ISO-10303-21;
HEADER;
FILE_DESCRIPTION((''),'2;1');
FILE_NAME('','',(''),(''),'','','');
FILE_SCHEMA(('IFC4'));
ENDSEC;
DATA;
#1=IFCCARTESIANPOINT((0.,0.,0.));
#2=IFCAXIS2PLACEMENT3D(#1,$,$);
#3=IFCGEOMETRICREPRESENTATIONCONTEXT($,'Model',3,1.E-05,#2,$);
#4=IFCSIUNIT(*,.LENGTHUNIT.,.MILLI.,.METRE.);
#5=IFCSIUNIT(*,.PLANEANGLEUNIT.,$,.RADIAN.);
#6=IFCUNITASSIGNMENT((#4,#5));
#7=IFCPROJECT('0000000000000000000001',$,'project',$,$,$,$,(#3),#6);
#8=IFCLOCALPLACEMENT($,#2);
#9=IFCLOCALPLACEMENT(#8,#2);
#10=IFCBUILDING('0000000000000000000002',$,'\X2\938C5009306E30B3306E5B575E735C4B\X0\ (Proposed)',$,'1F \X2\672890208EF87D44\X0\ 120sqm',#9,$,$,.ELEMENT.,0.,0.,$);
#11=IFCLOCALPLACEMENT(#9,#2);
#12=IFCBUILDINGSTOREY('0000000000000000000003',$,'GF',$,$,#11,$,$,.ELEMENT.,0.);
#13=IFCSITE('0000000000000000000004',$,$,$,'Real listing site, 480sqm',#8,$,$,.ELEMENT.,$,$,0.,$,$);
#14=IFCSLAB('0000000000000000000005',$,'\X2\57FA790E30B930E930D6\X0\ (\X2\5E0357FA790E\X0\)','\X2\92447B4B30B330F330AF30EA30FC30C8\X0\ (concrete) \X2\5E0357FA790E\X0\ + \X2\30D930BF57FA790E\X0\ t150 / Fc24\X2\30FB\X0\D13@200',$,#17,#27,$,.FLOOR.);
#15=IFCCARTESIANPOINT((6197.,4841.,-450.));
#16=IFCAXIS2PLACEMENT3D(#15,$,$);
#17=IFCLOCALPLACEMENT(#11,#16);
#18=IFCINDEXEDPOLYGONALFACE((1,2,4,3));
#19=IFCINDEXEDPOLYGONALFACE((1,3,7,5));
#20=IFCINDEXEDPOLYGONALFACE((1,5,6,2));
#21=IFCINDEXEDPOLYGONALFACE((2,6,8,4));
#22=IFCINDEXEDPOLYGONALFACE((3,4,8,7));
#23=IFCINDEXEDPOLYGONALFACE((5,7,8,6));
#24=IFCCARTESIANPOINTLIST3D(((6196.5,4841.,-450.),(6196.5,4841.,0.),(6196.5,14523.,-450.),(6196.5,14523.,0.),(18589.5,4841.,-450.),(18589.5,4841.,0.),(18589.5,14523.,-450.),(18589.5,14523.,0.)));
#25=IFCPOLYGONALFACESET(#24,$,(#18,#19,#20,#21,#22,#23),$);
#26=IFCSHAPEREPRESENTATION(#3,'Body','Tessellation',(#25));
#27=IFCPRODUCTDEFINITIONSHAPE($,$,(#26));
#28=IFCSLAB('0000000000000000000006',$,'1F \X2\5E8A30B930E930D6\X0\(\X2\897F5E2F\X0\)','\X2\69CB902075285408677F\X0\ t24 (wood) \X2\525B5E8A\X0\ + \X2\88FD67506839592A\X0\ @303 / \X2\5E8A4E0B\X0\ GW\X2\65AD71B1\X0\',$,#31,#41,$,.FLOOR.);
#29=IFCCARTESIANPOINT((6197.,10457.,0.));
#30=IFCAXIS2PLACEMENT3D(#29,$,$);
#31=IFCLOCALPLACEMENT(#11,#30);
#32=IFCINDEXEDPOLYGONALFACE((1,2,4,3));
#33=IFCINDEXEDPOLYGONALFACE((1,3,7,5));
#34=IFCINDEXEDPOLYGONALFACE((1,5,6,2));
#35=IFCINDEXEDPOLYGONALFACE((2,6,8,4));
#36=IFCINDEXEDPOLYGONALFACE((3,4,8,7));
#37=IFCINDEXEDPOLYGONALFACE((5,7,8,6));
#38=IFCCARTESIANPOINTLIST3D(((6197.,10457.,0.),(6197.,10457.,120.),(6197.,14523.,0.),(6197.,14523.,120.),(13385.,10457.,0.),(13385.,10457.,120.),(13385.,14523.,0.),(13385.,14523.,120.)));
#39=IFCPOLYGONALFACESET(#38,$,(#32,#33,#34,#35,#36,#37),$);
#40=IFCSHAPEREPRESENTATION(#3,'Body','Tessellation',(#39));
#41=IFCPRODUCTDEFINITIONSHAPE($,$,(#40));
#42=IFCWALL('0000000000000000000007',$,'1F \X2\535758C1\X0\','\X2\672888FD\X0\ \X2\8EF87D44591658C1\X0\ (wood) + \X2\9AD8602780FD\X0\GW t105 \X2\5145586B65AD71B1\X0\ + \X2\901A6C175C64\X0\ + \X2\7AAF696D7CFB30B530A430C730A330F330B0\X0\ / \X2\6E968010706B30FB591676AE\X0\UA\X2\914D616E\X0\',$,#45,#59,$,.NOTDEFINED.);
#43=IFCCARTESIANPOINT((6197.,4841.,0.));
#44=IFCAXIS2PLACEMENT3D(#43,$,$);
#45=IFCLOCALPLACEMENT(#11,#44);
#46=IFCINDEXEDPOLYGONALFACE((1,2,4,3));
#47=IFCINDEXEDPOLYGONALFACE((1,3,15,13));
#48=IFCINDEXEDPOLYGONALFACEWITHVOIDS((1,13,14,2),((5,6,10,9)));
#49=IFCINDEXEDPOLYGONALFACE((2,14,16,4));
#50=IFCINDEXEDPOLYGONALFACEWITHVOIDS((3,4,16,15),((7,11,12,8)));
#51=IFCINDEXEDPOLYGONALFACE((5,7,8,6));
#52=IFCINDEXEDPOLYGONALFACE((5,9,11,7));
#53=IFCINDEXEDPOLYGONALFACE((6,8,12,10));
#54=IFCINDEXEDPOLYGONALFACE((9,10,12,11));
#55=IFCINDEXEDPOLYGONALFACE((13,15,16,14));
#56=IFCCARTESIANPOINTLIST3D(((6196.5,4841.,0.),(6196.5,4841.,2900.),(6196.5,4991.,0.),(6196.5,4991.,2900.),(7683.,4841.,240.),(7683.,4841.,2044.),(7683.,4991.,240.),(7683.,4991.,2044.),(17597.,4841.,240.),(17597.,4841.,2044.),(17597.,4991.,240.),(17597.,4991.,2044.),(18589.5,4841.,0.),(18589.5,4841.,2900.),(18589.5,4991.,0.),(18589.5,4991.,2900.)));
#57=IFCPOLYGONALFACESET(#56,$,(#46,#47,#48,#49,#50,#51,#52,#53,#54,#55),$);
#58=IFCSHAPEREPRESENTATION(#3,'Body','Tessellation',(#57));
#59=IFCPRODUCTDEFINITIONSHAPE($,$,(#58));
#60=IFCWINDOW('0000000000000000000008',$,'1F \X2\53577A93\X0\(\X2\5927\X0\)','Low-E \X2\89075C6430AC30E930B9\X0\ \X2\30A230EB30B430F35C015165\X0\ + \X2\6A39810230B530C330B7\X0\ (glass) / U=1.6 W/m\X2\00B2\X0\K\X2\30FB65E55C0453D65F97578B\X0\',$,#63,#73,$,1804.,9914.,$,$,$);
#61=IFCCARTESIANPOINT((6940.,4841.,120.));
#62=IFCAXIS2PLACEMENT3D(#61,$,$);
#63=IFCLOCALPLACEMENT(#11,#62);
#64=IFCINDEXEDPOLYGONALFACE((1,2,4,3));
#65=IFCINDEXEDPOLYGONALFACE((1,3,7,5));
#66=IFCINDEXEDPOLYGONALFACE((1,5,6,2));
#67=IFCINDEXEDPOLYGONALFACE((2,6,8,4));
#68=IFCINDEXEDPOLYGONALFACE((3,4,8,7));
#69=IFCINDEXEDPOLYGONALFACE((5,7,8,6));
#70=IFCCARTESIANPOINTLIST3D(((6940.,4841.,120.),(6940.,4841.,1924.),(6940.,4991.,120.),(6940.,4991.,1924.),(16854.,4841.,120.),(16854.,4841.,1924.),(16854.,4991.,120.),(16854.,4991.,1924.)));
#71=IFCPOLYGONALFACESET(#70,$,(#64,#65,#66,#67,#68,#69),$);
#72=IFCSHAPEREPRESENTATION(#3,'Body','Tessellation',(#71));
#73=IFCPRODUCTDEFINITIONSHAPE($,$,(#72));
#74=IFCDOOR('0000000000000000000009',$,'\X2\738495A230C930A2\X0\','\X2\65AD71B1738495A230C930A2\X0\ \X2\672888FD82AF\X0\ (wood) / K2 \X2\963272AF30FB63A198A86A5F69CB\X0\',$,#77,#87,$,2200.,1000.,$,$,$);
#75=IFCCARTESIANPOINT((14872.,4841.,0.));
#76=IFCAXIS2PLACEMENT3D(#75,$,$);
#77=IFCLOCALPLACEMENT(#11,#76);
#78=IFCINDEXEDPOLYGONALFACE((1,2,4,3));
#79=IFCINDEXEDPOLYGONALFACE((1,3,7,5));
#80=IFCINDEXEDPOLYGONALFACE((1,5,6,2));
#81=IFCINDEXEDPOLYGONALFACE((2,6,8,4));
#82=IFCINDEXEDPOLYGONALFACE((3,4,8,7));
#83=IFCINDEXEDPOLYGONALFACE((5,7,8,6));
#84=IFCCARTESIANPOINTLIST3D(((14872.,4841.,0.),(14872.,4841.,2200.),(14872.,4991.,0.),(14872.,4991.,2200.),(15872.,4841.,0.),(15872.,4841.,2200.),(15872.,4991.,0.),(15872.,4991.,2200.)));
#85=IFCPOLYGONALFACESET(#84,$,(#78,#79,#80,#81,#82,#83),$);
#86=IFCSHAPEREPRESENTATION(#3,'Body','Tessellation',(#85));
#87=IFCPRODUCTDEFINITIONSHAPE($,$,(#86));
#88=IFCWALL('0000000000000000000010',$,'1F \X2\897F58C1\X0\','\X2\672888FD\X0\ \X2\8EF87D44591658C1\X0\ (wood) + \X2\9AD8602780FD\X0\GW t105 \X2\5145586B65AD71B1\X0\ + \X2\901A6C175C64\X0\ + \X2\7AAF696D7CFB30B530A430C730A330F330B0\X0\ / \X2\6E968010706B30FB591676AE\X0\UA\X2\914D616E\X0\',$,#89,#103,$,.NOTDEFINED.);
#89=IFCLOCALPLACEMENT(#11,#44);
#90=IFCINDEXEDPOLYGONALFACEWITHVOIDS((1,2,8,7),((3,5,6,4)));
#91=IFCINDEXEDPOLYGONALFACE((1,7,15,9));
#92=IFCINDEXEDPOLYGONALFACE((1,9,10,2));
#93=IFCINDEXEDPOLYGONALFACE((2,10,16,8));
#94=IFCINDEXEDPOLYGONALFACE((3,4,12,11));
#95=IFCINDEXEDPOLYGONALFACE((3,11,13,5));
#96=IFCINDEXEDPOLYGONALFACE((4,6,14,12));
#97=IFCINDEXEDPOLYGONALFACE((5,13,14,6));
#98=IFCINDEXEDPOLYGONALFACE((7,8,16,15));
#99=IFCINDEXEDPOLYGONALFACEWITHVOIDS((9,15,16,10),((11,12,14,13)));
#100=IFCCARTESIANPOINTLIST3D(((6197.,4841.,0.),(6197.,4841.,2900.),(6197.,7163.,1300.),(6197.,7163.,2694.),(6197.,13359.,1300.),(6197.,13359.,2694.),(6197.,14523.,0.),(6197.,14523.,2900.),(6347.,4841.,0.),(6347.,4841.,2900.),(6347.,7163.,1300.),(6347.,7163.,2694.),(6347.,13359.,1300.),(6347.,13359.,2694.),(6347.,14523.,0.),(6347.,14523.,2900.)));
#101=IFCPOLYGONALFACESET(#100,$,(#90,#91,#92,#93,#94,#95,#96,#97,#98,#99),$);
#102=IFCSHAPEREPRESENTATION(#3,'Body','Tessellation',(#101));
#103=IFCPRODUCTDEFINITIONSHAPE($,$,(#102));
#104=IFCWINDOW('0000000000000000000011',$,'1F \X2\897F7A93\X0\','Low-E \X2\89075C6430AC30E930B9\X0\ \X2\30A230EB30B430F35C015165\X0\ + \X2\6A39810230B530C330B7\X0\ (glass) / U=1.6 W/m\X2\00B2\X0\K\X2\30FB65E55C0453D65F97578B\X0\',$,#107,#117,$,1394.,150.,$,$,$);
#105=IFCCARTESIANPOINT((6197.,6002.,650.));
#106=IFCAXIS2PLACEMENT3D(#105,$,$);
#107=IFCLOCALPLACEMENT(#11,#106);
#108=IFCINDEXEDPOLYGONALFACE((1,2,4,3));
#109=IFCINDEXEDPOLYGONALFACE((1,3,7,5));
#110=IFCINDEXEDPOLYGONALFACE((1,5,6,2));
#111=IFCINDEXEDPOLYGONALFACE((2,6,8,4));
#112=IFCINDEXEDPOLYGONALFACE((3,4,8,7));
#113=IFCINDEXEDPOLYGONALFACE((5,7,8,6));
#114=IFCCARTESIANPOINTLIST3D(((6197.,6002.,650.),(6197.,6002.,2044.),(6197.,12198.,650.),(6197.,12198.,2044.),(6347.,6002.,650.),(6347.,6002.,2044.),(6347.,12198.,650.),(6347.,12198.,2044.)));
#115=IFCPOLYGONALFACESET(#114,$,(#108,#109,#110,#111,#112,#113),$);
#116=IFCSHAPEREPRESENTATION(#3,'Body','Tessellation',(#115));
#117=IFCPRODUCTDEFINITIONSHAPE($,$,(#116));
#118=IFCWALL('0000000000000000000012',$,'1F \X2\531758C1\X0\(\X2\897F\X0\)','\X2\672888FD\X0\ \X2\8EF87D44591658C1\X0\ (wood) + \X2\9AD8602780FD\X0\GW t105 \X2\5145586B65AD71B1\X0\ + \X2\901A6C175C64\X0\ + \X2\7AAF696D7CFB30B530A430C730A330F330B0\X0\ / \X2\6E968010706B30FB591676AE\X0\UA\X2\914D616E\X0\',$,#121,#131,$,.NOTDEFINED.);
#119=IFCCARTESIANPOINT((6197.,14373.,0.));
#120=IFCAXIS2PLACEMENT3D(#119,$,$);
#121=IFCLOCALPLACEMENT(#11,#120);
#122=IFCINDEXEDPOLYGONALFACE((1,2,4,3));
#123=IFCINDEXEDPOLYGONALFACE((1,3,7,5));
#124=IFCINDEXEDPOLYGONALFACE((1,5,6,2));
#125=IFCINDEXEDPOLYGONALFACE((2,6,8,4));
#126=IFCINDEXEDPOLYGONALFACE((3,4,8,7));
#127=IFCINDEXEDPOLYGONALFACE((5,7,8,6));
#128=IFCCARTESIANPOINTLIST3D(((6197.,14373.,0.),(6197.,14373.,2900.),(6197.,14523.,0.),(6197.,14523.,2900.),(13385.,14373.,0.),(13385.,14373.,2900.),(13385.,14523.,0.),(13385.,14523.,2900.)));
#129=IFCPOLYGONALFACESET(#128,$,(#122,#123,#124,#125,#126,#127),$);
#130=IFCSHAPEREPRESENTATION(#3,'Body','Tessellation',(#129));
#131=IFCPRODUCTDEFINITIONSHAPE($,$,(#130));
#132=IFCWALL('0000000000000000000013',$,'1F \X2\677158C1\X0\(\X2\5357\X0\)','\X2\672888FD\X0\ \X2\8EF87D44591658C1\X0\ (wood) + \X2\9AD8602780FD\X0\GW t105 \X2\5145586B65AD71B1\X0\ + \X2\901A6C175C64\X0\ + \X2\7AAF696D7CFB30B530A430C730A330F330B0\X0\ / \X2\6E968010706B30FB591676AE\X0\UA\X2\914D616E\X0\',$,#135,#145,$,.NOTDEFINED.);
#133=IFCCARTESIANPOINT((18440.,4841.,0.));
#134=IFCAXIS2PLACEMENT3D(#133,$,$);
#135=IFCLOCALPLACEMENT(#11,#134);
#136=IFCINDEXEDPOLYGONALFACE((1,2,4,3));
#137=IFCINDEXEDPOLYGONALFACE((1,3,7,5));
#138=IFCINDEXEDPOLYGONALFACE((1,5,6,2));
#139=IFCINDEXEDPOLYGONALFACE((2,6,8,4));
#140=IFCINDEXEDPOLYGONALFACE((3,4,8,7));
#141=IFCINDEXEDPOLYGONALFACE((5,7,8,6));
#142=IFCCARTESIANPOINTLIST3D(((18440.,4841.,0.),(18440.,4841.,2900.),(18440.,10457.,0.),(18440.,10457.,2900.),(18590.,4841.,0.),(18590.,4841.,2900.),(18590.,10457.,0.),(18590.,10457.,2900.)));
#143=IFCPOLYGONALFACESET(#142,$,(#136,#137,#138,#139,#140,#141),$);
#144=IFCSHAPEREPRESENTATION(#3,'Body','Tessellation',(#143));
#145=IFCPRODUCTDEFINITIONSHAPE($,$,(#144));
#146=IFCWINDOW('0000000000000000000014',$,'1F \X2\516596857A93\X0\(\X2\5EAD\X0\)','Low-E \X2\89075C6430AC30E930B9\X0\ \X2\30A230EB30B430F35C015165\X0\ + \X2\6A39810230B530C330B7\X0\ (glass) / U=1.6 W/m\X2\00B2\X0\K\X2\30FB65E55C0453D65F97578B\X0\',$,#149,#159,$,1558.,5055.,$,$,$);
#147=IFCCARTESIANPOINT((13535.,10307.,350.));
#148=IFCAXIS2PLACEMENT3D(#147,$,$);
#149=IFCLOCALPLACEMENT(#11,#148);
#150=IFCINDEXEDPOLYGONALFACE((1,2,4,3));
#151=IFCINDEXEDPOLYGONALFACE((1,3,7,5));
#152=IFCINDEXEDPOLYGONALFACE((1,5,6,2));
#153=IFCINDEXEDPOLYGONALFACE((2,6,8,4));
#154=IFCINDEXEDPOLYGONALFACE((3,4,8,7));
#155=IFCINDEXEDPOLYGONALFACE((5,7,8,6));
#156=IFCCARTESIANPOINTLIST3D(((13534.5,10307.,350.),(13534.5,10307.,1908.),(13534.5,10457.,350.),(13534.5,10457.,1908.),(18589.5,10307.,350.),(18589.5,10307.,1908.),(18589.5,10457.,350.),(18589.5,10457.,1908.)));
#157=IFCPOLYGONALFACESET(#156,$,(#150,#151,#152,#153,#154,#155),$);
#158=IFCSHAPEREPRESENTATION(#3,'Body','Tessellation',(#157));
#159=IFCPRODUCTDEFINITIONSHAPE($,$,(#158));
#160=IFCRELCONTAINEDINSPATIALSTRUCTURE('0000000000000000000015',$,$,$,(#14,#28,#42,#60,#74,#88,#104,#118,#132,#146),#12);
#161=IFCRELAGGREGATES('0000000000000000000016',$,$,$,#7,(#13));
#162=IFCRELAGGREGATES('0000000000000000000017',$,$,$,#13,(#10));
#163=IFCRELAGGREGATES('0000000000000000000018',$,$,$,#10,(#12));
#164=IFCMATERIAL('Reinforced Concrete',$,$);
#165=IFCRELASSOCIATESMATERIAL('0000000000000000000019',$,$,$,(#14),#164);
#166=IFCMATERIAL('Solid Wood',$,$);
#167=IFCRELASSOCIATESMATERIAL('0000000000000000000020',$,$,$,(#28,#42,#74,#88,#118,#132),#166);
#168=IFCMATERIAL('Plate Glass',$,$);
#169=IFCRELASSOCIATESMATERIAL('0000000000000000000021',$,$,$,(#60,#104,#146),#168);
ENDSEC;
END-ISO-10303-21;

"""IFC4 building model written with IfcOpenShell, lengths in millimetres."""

from ifc_helpers import new_model, si_unit, frame, frame_2d, origin, place, context, project, spatial, rectangle, extrude, material, element, fill, save


model = new_model("IFC4")

# Units and contexts
model_context = context("Model", 3, precision=1e-05, world=origin())
ifc_project = project(units=[si_unit("LENGTHUNIT", "METRE", prefix="MILLI"), si_unit("PLANEANGLEUNIT", "RADIAN")], contexts=[model_context])

# Site, building, storey
site_placement = place(None, origin())
site = spatial("IfcSite", under=ifc_project, at=site_placement, ObjectType="Real listing site, 480sqm", CompositionType="ELEMENT", RefElevation=0.0)
building_placement = place(site_placement, origin())
building = spatial("IfcBuilding", under=site, at=building_placement, Name="鎌倉のコの字平屋 (Proposed)", ObjectType="1F 木造軸組 120sqm", CompositionType="ELEMENT", ElevationOfRefHeight=0.0, ElevationOfTerrain=0.0)
storey_placement = place(building_placement, origin())
storey = spatial("IfcBuildingStorey", under=building, at=storey_placement, Name="GF", CompositionType="ELEMENT", Elevation=0.0)

# Slabs
ifc_material_1 = material(Name="Reinforced Concrete")
slab_1_placement = place(storey_placement, frame((6197.0, 4841.0, -450.0)))
element("IfcSlab", 1, at=slab_1_placement, inside=storey, material=ifc_material_1, Name="基礎スラブ (布基礎)", Description="鉄筋コンクリート (concrete) 布基礎 + ベタ基礎 t150 / Fc24・D13@200", PredefinedType="FLOOR", context=model_context, shape_type="SweptSolid", body=[
    extrude(rectangle(XDim=12393.0, YDim=9682.0, at=frame_2d((6196.0, 4841.0))), frame((6197.0, 4841.0, -450.0)), (0.0, 0.0, 1.0), 450.0),
])
ifc_material_2 = material(Name="Solid Wood")
slab_2_placement = place(storey_placement, frame((6197.0, 10457.0, 0.0)))
element("IfcSlab", 2, at=slab_2_placement, inside=storey, material=ifc_material_2, Name="1F 床スラブ(西帯)", Description="構造用合板 t24 (wood) 剛床 + 製材根太 @303 / 床下 GW断熱", PredefinedType="FLOOR", context=model_context, shape_type="SweptSolid", body=[
    extrude(rectangle(XDim=7188.0, YDim=4066.0, at=frame_2d((3594.0, 2033.0))), frame((6197.0, 10457.0, 0.0)), (0.0, 0.0, 1.0), 120.0),
])

# Wall, openings, window, door
wall_1_placement = place(storey_placement, frame((6197.0, 4841.0, 0.0)))
wall_1 = element("IfcWall", 3, at=wall_1_placement, inside=storey, material=ifc_material_2, Name="1F 南壁", Description="木製 軸組外壁 (wood) + 高性能GW t105 充填断熱 + 通気層 + 窯業系サイディング / 準耐火・外皮UA配慮", PredefinedType="NOTDEFINED", context=model_context, shape_type="SweptSolid", body=[
    extrude(rectangle(XDim=12393.0, YDim=150.0, at=frame_2d((6196.0, 75.0))), frame((6197.0, 4841.0, 0.0)), (0.0, 0.0, 1.0), 2900.0),
])
opening_1_placement = place(storey_placement, frame((6940.0, 4841.0, 120.0)))
opening_1 = element("IfcOpeningElement", 4, at=opening_1_placement, cuts=wall_1, PredefinedType="NOTDEFINED", context=model_context, shape_type="SweptSolid", body=[
    extrude(rectangle(XDim=9914.0, YDim=150.0, at=frame_2d((4957.0, 75.0))), frame((6940.0, 4841.0, 120.0)), (0.0, 0.0, 1.0), 1804.0),
])
opening_2_placement = place(storey_placement, frame((14872.0, 4841.0, 0.0)))
opening_2 = element("IfcOpeningElement", 5, at=opening_2_placement, cuts=wall_1, PredefinedType="NOTDEFINED", context=model_context, shape_type="SweptSolid", body=[
    extrude(rectangle(XDim=1000.0, YDim=150.0, at=frame_2d((500.0, 75.0))), frame((14872.0, 4841.0, 0.0)), (0.0, 0.0, 1.0), 2200.0),
])
ifc_material_3 = material(Name="Plate Glass")
window_1_placement = place(storey_placement, frame((6940.0, 4841.0, 120.0)))
window_1 = element("IfcWindow", 6, at=window_1_placement, inside=storey, material=ifc_material_3, Name="1F 南窓(大)", Description="Low-E 複層ガラス アルゴン封入 + 樹脂サッシ (glass) / U=1.6 W/m²K・日射取得型", OverallHeight=1804.0, OverallWidth=9914.0, context=model_context, shape_type="SweptSolid", body=[
    extrude(rectangle(XDim=9914.0, YDim=150.0, at=frame_2d((4957.0, 75.0))), frame((6940.0, 4841.0, 120.0)), (0.0, 0.0, 1.0), 1804.0),
])
fill(opening_1, window_1)
door_placement = place(storey_placement, frame((14872.0, 4841.0, 0.0)))
door = element("IfcDoor", 7, at=door_placement, inside=storey, material=ifc_material_2, Name="玄関ドア", Description="断熱玄関ドア 木製芯 (wood) / K2 防犯・採風機構", OverallHeight=2200.0, OverallWidth=1000.0, context=model_context, shape_type="SweptSolid", body=[
    extrude(rectangle(XDim=1000.0, YDim=150.0, at=frame_2d((500.0, 75.0))), frame((14872.0, 4841.0, 0.0)), (0.0, 0.0, 1.0), 2200.0),
])
fill(opening_2, door)

# Wall, opening, window
wall_2_placement = place(storey_placement, frame((6197.0, 4841.0, 0.0)))
wall_2 = element("IfcWall", 8, at=wall_2_placement, inside=storey, material=ifc_material_2, Name="1F 西壁", Description="木製 軸組外壁 (wood) + 高性能GW t105 充填断熱 + 通気層 + 窯業系サイディング / 準耐火・外皮UA配慮", PredefinedType="NOTDEFINED", context=model_context, shape_type="SweptSolid", body=[
    extrude(rectangle(XDim=150.0, YDim=9682.0, at=frame_2d((75.0, 4841.0))), frame((6197.0, 4841.0, 0.0)), (0.0, 0.0, 1.0), 2900.0),
])
opening_3_placement = place(storey_placement, frame((6197.0, 6002.0, 650.0)))
opening_3 = element("IfcOpeningElement", 9, at=opening_3_placement, cuts=wall_2, PredefinedType="NOTDEFINED", context=model_context, shape_type="SweptSolid", body=[
    extrude(rectangle(XDim=150.0, YDim=6196.0, at=frame_2d((75.0, 3098.0))), frame((6197.0, 6002.0, 650.0)), (0.0, 0.0, 1.0), 1394.0),
])
window_2_placement = place(storey_placement, frame((6197.0, 6002.0, 650.0)))
window_2 = element("IfcWindow", 10, at=window_2_placement, inside=storey, material=ifc_material_3, Name="1F 西窓", Description="Low-E 複層ガラス アルゴン封入 + 樹脂サッシ (glass) / U=1.6 W/m²K・日射取得型", OverallHeight=1394.0, OverallWidth=150.0, context=model_context, shape_type="SweptSolid", body=[
    extrude(rectangle(XDim=150.0, YDim=6196.0, at=frame_2d((75.0, 3098.0))), frame((6197.0, 6002.0, 650.0)), (0.0, 0.0, 1.0), 1394.0),
])
fill(opening_3, window_2)

# Wall
wall_3_placement = place(storey_placement, frame((6197.0, 14373.0, 0.0)))
element("IfcWall", 11, at=wall_3_placement, inside=storey, material=ifc_material_2, Name="1F 北壁(西)", Description="木製 軸組外壁 (wood) + 高性能GW t105 充填断熱 + 通気層 + 窯業系サイディング / 準耐火・外皮UA配慮", PredefinedType="NOTDEFINED", context=model_context, shape_type="SweptSolid", body=[
    extrude(rectangle(XDim=7188.0, YDim=150.0, at=frame_2d((3594.0, 75.0))), frame((6197.0, 14373.0, 0.0)), (0.0, 0.0, 1.0), 2900.0),
])

# Wall, opening, window
wall_4_placement = place(storey_placement, frame((18440.0, 4841.0, 0.0)))
wall_4 = element("IfcWall", 12, at=wall_4_placement, inside=storey, material=ifc_material_2, Name="1F 東壁(南)", Description="木製 軸組外壁 (wood) + 高性能GW t105 充填断熱 + 通気層 + 窯業系サイディング / 準耐火・外皮UA配慮", PredefinedType="NOTDEFINED", context=model_context, shape_type="SweptSolid", body=[
    extrude(rectangle(XDim=150.0, YDim=5616.0, at=frame_2d((75.0, 2808.0))), frame((18440.0, 4841.0, 0.0)), (0.0, 0.0, 1.0), 2900.0),
])
opening_4_placement = place(storey_placement, frame((13535.0, 10307.0, 350.0)))
opening_4 = element("IfcOpeningElement", 13, at=opening_4_placement, cuts=wall_4, PredefinedType="NOTDEFINED", context=model_context, shape_type="SweptSolid", body=[
    extrude(rectangle(XDim=5055.0, YDim=150.0, at=frame_2d((2527.0, 75.0))), frame((13535.0, 10307.0, 350.0)), (0.0, 0.0, 1.0), 1558.0),
])
window_3_placement = place(storey_placement, frame((13535.0, 10307.0, 350.0)))
window_3 = element("IfcWindow", 14, at=window_3_placement, inside=storey, material=ifc_material_3, Name="1F 入隅窓(庭)", Description="Low-E 複層ガラス アルゴン封入 + 樹脂サッシ (glass) / U=1.6 W/m²K・日射取得型", OverallHeight=1558.0, OverallWidth=5055.0, context=model_context, shape_type="SweptSolid", body=[
    extrude(rectangle(XDim=5055.0, YDim=150.0, at=frame_2d((2527.0, 75.0))), frame((13535.0, 10307.0, 350.0)), (0.0, 0.0, 1.0), 1558.0),
])
fill(opening_4, window_3)

save(model, "model.ifc")
